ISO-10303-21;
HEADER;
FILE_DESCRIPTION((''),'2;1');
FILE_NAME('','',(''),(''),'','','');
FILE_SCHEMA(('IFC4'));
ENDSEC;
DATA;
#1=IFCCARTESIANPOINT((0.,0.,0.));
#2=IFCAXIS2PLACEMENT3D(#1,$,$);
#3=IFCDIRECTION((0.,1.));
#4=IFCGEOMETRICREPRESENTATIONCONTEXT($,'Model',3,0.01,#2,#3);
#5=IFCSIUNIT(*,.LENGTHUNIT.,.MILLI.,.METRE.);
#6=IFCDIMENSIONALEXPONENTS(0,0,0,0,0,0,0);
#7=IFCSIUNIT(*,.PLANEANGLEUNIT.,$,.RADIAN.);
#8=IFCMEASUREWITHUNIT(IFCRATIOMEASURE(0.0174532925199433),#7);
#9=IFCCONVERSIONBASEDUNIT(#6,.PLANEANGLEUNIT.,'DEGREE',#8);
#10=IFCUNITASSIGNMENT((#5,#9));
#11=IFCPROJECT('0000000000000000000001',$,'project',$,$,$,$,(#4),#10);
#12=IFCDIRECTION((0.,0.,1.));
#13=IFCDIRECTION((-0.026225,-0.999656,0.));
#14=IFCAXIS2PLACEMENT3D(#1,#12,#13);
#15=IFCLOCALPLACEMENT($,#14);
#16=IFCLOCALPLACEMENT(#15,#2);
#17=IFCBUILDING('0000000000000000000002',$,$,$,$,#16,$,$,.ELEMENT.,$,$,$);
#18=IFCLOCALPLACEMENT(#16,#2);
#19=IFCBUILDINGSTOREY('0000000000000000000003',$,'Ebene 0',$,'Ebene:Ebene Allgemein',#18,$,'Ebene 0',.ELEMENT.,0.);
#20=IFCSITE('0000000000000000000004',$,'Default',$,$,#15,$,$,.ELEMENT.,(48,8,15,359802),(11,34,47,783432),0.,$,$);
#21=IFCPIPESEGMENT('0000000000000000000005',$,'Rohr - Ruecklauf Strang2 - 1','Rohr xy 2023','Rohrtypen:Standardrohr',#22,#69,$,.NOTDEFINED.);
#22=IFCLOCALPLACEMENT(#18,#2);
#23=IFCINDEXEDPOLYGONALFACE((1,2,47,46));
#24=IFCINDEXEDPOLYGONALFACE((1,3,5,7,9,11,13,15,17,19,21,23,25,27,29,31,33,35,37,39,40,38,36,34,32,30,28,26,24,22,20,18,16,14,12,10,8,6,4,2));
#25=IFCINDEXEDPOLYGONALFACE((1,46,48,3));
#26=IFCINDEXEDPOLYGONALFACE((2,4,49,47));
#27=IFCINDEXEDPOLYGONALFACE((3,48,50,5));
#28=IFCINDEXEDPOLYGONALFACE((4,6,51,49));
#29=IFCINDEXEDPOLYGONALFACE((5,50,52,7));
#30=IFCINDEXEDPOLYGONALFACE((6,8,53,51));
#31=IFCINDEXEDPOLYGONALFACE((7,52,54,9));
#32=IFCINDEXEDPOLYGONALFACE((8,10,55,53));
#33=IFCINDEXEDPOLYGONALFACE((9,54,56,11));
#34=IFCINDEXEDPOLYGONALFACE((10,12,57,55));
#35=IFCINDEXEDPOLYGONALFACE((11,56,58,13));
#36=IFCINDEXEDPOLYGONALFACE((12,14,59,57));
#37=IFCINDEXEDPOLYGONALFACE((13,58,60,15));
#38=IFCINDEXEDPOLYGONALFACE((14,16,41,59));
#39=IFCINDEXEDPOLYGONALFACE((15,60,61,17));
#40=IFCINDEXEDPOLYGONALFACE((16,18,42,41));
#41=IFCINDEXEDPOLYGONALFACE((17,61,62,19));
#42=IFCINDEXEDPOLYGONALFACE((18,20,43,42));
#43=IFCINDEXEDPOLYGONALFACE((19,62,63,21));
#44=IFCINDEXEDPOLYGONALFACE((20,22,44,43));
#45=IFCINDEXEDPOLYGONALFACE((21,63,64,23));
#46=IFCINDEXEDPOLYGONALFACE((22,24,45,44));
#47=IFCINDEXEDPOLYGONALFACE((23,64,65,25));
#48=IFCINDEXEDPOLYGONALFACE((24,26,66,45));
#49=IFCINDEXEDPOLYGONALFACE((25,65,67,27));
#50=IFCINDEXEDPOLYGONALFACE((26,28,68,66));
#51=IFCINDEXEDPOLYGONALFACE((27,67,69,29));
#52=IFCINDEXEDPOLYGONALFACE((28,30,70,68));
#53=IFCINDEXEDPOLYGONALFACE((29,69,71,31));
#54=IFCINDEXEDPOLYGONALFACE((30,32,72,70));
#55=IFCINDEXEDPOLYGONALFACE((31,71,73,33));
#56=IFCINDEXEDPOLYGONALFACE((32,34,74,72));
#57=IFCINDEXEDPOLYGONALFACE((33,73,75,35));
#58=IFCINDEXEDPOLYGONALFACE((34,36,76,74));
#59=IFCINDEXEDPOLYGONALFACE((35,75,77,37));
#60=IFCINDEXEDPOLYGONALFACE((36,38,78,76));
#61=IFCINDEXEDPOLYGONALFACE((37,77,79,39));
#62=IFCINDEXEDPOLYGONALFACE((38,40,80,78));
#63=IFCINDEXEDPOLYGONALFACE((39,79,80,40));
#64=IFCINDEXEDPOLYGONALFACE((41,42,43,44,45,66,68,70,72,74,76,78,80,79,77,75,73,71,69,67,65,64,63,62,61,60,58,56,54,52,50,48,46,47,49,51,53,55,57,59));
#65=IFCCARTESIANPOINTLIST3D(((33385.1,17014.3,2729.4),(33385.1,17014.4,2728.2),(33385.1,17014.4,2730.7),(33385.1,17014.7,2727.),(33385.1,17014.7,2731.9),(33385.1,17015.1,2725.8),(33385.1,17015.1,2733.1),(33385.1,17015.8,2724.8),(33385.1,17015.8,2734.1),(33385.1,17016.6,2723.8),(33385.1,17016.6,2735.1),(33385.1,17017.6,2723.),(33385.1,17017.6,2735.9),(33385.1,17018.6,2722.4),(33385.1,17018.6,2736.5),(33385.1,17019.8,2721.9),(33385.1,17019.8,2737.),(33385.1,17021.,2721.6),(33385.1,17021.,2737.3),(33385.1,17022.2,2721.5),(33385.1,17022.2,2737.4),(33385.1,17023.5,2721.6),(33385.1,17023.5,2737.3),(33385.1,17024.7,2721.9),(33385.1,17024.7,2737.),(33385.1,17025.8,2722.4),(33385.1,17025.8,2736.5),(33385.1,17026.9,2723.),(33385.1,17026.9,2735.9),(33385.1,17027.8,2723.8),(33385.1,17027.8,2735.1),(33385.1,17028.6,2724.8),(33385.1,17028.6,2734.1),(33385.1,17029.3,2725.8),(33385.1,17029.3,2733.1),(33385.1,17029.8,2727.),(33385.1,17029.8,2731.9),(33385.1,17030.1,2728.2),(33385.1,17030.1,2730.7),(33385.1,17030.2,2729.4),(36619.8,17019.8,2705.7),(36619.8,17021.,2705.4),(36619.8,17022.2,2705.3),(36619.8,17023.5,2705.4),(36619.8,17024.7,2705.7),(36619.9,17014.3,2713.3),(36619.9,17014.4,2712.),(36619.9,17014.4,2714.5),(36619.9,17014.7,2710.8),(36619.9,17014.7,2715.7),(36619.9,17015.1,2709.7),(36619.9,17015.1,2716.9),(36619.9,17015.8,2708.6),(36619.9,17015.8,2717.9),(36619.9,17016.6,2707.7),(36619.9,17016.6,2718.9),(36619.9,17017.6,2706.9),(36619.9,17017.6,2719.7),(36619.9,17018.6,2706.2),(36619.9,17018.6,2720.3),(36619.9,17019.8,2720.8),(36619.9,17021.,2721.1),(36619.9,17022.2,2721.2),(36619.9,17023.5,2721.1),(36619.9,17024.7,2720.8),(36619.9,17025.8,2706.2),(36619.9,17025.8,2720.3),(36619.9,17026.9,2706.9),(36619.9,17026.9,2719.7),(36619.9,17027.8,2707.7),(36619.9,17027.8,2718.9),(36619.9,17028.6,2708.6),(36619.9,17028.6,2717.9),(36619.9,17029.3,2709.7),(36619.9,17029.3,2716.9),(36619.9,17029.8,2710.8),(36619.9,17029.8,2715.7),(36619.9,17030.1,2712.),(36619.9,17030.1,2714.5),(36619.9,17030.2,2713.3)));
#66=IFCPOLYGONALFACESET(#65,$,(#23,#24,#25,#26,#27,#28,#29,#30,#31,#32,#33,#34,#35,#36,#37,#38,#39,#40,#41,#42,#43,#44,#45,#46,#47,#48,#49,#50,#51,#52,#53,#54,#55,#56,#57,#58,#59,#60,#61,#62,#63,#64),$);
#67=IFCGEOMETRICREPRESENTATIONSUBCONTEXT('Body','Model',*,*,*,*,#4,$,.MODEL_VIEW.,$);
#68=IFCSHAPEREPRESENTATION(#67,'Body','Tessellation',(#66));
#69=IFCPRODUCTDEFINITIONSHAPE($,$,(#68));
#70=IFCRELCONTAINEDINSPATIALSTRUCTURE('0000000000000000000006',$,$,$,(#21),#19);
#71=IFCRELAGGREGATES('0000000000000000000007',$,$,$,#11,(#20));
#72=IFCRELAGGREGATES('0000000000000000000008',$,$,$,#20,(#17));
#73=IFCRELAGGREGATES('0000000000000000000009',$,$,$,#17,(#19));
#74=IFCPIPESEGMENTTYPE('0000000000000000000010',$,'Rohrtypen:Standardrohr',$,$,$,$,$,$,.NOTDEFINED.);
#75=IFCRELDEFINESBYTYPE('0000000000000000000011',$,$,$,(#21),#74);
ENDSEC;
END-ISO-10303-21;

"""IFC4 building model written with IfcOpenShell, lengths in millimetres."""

from ifc_helpers import new_model, entity, si_unit, converted_unit, direction, frame, origin, place, context, subcontext, project, spatial, indexed_curve, outline, extrude, type_object, element, save


model = new_model("IFC4")

# Units and contexts
model_context = context("Model", 3, precision=0.01, world=origin(), true_north=direction((0.0, 1.0)))
body_context = subcontext(model_context, "Body", "Model", "MODEL_VIEW")
ifc_project = project(units=[si_unit("LENGTHUNIT", "METRE", prefix="MILLI"), converted_unit("PLANEANGLEUNIT", "DEGREE", entity("IfcRatioMeasure", 0.0174532925199433), si_unit("PLANEANGLEUNIT", "RADIAN"), dimensions=[0, 0, 0, 0, 0, 0, 0])], contexts=[model_context])

# Site, building, storey
site_placement = place(None, frame((0.0, 0.0, 0.0), z_axis=(0.0, 0.0, 1.0), x_axis=(-0.026225, -0.999656, 0.0)))
site = spatial("IfcSite", under=ifc_project, at=site_placement, Name="Default", CompositionType="ELEMENT", RefLatitude=(48, 8, 15, 359802), RefLongitude=(11, 34, 47, 783432), RefElevation=0.0)
building_placement = place(site_placement, origin())
building = spatial("IfcBuilding", under=site, at=building_placement, CompositionType="ELEMENT")
storey_placement = place(building_placement, origin())
storey = spatial("IfcBuildingStorey", under=building, at=storey_placement, Name="Ebene 0", ObjectType="Ebene:Ebene Allgemein", LongName="Ebene 0", CompositionType="ELEMENT", Elevation=0.0)

# Pipe segment
pipe_segment_type = type_object("IfcPipeSegmentType", Name="Rohrtypen:Standardrohr", PredefinedType="NOTDEFINED")
pipe_segment_1_placement = place(storey_placement, origin())
element("IfcPipeSegment", 1, at=pipe_segment_1_placement, inside=storey, type_object=pipe_segment_type, Name="Rohr - Ruecklauf Strang2 - 1", Description="Rohr xy 2023", ObjectType="Rohrtypen:Standardrohr", PredefinedType="NOTDEFINED", context=body_context, shape_type="SweptSolid", body=[
    extrude(outline(indexed_curve([(7.9, 0.0), (7.8, 1.2), (7.6, 2.5), (7.1, 3.6), (6.4, 4.7), (5.6, 5.6), (4.7, 6.4), (3.6, 7.1), (2.5, 7.6), (1.2, 7.8), (0.0, 7.9), (-1.2, 7.8), (-2.5, 7.6), (-3.6, 7.1), (-4.7, 6.4), (-5.6, 5.6), (-6.4, 4.7), (-7.1, 3.6), (-7.6, 2.5), (-7.8, 1.2), (-7.9, 0.0), (-7.8, -1.2), (-7.6, -2.5), (-7.1, -3.6), (-6.4, -4.7), (-5.6, -5.6), (-4.7, -6.4), (-3.6, -7.1), (-2.5, -7.6), (-1.2, -7.8), (0.0, -7.9), (1.2, -7.8), (2.5, -7.6), (3.6, -7.1), (4.7, -6.4), (5.6, -5.6), (6.4, -4.7), (7.1, -3.6), (7.6, -2.5), (7.8, -1.2), (7.9, 0.0)], self_intersect=False)), frame((36619.9, 17022.2, 2713.3), z_axis=(-0.999988, 0.0, 0.005), x_axis=(0.0, 1.0, 0.0)), (0.0, 0.0, 1.0), 3234.8),
])

save(model, "model.ifc")
